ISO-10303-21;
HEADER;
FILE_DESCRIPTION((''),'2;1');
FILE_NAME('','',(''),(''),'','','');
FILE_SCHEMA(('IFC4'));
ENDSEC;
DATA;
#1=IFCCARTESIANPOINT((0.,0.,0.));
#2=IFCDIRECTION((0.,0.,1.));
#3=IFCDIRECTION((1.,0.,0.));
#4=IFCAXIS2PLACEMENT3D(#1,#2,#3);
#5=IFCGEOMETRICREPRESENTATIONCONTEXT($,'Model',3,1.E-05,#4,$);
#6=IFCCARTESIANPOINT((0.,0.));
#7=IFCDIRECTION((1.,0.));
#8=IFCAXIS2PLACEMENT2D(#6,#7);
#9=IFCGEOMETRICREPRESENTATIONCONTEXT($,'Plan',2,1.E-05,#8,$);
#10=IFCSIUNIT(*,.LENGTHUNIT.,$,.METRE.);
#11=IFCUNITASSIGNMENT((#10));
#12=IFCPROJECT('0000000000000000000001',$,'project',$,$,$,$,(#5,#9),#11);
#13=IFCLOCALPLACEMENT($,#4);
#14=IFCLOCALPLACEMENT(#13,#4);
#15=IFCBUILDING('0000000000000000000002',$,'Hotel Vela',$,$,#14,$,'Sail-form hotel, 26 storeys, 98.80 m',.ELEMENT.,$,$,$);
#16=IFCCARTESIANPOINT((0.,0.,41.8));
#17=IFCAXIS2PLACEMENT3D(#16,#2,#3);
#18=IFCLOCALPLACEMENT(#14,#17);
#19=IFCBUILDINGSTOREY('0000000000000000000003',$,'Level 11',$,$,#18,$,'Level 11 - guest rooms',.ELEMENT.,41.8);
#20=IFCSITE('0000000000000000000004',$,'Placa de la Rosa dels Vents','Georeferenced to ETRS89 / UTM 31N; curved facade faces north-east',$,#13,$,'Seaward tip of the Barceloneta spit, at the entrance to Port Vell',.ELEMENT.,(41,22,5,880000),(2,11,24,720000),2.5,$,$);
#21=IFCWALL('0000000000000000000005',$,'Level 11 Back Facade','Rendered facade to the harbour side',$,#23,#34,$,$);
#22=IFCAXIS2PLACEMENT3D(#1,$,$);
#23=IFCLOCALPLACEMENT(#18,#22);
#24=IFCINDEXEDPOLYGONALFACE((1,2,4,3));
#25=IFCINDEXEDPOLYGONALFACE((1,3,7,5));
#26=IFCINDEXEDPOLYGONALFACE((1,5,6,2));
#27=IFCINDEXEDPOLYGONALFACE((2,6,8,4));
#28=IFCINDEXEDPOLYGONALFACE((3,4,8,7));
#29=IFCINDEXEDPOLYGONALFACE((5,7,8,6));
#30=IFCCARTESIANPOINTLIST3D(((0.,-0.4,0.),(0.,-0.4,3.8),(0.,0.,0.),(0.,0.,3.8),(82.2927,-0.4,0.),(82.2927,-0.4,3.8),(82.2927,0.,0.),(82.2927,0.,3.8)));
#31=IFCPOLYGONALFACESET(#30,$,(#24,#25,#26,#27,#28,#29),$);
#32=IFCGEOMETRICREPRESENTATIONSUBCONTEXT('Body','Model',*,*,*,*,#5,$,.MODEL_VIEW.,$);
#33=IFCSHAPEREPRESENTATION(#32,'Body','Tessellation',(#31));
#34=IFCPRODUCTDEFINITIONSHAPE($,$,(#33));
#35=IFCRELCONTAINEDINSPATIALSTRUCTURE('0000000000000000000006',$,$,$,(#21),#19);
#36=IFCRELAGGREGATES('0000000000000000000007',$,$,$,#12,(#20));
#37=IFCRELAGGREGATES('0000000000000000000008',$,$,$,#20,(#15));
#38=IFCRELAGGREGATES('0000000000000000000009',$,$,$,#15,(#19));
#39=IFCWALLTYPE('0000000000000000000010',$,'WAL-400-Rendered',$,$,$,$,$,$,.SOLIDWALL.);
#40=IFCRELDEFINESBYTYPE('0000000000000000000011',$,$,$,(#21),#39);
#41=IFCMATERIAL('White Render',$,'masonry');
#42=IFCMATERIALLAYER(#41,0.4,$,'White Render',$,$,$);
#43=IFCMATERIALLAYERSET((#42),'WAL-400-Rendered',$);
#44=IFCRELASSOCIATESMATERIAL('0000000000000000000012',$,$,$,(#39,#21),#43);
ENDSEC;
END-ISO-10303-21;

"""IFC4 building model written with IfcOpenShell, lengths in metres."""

from ifc_helpers import new_model, si_unit, frame, origin_with_axes, origin_2d_with_axis, place, context, subcontext, project, spatial, line, indexed_curve, outline, extrude, material, layer, layer_set, layer_usage, type_object, element, save


model = new_model("IFC4")

# Units and contexts
model_context = context("Model", 3, precision=1e-05, world=origin_with_axes())
plan_context = context("Plan", 2, precision=1e-05, world=origin_2d_with_axis())
body_context = subcontext(model_context, "Body", "Model", "MODEL_VIEW")
ifc_project = project(units=[si_unit("LENGTHUNIT", "METRE")], contexts=[model_context, plan_context])

# Site, building, storey
site_placement = place(None, origin_with_axes())
site = spatial("IfcSite", under=ifc_project, at=site_placement, Name="Placa de la Rosa dels Vents", Description="Georeferenced to ETRS89 / UTM 31N; curved facade faces north-east", LongName="Seaward tip of the Barceloneta spit, at the entrance to Port Vell", CompositionType="ELEMENT", RefLatitude=(41, 22, 5, 880000), RefLongitude=(2, 11, 24, 720000), RefElevation=2.5)
building_placement = place(site_placement, origin_with_axes())
building = spatial("IfcBuilding", under=site, at=building_placement, Name="Hotel Vela", LongName="Sail-form hotel, 26 storeys, 98.80 m", CompositionType="ELEMENT")
storey_placement = place(building_placement, frame((0.0, 0.0, 41.8), z_axis=(0.0, 0.0, 1.0), x_axis=(1.0, 0.0, 0.0)))
storey = spatial("IfcBuildingStorey", under=building, at=storey_placement, Name="Level 11", LongName="Level 11 - guest rooms", CompositionType="ELEMENT", Elevation=41.8)

# Wall
ifc_material_1 = material(Name="White Render", Category="masonry")
ifc_layer_1 = layer(ifc_material_1, 0.4, Name="White Render")
ifc_layer_set_1 = layer_set([ifc_layer_1], Name="WAL-400-Rendered")
ifc_layer_usage_1 = layer_usage(ifc_layer_set_1, "AXIS2", "POSITIVE", 0.0)
wall_type = type_object("IfcWallType", Name="WAL-400-Rendered", PredefinedType="SOLIDWALL", material=ifc_layer_set_1)
wall_placement = place(storey_placement, frame((0.0, -0.4, 0.0), z_axis=(0.0, 0.0, 1.0), x_axis=(1.0, 0.0, 0.0)))
element("IfcWall", 1, at=wall_placement, inside=storey, type_object=wall_type, material=ifc_layer_usage_1, Name="Level 11 Back Facade", Description="Rendered facade to the harbour side", context=body_context, shape_type="SweptSolid", body=[
    extrude(outline(indexed_curve([(0.0, 0.0), (82.2927, 0.0), (82.2927, 0.4), (0.0, 0.4)], segments=[line(1, 2, 3, 4, 1)])), origin_with_axes(), (0.0, 0.0, 1.0), 3.8),
])

save(model, "model.ifc")
